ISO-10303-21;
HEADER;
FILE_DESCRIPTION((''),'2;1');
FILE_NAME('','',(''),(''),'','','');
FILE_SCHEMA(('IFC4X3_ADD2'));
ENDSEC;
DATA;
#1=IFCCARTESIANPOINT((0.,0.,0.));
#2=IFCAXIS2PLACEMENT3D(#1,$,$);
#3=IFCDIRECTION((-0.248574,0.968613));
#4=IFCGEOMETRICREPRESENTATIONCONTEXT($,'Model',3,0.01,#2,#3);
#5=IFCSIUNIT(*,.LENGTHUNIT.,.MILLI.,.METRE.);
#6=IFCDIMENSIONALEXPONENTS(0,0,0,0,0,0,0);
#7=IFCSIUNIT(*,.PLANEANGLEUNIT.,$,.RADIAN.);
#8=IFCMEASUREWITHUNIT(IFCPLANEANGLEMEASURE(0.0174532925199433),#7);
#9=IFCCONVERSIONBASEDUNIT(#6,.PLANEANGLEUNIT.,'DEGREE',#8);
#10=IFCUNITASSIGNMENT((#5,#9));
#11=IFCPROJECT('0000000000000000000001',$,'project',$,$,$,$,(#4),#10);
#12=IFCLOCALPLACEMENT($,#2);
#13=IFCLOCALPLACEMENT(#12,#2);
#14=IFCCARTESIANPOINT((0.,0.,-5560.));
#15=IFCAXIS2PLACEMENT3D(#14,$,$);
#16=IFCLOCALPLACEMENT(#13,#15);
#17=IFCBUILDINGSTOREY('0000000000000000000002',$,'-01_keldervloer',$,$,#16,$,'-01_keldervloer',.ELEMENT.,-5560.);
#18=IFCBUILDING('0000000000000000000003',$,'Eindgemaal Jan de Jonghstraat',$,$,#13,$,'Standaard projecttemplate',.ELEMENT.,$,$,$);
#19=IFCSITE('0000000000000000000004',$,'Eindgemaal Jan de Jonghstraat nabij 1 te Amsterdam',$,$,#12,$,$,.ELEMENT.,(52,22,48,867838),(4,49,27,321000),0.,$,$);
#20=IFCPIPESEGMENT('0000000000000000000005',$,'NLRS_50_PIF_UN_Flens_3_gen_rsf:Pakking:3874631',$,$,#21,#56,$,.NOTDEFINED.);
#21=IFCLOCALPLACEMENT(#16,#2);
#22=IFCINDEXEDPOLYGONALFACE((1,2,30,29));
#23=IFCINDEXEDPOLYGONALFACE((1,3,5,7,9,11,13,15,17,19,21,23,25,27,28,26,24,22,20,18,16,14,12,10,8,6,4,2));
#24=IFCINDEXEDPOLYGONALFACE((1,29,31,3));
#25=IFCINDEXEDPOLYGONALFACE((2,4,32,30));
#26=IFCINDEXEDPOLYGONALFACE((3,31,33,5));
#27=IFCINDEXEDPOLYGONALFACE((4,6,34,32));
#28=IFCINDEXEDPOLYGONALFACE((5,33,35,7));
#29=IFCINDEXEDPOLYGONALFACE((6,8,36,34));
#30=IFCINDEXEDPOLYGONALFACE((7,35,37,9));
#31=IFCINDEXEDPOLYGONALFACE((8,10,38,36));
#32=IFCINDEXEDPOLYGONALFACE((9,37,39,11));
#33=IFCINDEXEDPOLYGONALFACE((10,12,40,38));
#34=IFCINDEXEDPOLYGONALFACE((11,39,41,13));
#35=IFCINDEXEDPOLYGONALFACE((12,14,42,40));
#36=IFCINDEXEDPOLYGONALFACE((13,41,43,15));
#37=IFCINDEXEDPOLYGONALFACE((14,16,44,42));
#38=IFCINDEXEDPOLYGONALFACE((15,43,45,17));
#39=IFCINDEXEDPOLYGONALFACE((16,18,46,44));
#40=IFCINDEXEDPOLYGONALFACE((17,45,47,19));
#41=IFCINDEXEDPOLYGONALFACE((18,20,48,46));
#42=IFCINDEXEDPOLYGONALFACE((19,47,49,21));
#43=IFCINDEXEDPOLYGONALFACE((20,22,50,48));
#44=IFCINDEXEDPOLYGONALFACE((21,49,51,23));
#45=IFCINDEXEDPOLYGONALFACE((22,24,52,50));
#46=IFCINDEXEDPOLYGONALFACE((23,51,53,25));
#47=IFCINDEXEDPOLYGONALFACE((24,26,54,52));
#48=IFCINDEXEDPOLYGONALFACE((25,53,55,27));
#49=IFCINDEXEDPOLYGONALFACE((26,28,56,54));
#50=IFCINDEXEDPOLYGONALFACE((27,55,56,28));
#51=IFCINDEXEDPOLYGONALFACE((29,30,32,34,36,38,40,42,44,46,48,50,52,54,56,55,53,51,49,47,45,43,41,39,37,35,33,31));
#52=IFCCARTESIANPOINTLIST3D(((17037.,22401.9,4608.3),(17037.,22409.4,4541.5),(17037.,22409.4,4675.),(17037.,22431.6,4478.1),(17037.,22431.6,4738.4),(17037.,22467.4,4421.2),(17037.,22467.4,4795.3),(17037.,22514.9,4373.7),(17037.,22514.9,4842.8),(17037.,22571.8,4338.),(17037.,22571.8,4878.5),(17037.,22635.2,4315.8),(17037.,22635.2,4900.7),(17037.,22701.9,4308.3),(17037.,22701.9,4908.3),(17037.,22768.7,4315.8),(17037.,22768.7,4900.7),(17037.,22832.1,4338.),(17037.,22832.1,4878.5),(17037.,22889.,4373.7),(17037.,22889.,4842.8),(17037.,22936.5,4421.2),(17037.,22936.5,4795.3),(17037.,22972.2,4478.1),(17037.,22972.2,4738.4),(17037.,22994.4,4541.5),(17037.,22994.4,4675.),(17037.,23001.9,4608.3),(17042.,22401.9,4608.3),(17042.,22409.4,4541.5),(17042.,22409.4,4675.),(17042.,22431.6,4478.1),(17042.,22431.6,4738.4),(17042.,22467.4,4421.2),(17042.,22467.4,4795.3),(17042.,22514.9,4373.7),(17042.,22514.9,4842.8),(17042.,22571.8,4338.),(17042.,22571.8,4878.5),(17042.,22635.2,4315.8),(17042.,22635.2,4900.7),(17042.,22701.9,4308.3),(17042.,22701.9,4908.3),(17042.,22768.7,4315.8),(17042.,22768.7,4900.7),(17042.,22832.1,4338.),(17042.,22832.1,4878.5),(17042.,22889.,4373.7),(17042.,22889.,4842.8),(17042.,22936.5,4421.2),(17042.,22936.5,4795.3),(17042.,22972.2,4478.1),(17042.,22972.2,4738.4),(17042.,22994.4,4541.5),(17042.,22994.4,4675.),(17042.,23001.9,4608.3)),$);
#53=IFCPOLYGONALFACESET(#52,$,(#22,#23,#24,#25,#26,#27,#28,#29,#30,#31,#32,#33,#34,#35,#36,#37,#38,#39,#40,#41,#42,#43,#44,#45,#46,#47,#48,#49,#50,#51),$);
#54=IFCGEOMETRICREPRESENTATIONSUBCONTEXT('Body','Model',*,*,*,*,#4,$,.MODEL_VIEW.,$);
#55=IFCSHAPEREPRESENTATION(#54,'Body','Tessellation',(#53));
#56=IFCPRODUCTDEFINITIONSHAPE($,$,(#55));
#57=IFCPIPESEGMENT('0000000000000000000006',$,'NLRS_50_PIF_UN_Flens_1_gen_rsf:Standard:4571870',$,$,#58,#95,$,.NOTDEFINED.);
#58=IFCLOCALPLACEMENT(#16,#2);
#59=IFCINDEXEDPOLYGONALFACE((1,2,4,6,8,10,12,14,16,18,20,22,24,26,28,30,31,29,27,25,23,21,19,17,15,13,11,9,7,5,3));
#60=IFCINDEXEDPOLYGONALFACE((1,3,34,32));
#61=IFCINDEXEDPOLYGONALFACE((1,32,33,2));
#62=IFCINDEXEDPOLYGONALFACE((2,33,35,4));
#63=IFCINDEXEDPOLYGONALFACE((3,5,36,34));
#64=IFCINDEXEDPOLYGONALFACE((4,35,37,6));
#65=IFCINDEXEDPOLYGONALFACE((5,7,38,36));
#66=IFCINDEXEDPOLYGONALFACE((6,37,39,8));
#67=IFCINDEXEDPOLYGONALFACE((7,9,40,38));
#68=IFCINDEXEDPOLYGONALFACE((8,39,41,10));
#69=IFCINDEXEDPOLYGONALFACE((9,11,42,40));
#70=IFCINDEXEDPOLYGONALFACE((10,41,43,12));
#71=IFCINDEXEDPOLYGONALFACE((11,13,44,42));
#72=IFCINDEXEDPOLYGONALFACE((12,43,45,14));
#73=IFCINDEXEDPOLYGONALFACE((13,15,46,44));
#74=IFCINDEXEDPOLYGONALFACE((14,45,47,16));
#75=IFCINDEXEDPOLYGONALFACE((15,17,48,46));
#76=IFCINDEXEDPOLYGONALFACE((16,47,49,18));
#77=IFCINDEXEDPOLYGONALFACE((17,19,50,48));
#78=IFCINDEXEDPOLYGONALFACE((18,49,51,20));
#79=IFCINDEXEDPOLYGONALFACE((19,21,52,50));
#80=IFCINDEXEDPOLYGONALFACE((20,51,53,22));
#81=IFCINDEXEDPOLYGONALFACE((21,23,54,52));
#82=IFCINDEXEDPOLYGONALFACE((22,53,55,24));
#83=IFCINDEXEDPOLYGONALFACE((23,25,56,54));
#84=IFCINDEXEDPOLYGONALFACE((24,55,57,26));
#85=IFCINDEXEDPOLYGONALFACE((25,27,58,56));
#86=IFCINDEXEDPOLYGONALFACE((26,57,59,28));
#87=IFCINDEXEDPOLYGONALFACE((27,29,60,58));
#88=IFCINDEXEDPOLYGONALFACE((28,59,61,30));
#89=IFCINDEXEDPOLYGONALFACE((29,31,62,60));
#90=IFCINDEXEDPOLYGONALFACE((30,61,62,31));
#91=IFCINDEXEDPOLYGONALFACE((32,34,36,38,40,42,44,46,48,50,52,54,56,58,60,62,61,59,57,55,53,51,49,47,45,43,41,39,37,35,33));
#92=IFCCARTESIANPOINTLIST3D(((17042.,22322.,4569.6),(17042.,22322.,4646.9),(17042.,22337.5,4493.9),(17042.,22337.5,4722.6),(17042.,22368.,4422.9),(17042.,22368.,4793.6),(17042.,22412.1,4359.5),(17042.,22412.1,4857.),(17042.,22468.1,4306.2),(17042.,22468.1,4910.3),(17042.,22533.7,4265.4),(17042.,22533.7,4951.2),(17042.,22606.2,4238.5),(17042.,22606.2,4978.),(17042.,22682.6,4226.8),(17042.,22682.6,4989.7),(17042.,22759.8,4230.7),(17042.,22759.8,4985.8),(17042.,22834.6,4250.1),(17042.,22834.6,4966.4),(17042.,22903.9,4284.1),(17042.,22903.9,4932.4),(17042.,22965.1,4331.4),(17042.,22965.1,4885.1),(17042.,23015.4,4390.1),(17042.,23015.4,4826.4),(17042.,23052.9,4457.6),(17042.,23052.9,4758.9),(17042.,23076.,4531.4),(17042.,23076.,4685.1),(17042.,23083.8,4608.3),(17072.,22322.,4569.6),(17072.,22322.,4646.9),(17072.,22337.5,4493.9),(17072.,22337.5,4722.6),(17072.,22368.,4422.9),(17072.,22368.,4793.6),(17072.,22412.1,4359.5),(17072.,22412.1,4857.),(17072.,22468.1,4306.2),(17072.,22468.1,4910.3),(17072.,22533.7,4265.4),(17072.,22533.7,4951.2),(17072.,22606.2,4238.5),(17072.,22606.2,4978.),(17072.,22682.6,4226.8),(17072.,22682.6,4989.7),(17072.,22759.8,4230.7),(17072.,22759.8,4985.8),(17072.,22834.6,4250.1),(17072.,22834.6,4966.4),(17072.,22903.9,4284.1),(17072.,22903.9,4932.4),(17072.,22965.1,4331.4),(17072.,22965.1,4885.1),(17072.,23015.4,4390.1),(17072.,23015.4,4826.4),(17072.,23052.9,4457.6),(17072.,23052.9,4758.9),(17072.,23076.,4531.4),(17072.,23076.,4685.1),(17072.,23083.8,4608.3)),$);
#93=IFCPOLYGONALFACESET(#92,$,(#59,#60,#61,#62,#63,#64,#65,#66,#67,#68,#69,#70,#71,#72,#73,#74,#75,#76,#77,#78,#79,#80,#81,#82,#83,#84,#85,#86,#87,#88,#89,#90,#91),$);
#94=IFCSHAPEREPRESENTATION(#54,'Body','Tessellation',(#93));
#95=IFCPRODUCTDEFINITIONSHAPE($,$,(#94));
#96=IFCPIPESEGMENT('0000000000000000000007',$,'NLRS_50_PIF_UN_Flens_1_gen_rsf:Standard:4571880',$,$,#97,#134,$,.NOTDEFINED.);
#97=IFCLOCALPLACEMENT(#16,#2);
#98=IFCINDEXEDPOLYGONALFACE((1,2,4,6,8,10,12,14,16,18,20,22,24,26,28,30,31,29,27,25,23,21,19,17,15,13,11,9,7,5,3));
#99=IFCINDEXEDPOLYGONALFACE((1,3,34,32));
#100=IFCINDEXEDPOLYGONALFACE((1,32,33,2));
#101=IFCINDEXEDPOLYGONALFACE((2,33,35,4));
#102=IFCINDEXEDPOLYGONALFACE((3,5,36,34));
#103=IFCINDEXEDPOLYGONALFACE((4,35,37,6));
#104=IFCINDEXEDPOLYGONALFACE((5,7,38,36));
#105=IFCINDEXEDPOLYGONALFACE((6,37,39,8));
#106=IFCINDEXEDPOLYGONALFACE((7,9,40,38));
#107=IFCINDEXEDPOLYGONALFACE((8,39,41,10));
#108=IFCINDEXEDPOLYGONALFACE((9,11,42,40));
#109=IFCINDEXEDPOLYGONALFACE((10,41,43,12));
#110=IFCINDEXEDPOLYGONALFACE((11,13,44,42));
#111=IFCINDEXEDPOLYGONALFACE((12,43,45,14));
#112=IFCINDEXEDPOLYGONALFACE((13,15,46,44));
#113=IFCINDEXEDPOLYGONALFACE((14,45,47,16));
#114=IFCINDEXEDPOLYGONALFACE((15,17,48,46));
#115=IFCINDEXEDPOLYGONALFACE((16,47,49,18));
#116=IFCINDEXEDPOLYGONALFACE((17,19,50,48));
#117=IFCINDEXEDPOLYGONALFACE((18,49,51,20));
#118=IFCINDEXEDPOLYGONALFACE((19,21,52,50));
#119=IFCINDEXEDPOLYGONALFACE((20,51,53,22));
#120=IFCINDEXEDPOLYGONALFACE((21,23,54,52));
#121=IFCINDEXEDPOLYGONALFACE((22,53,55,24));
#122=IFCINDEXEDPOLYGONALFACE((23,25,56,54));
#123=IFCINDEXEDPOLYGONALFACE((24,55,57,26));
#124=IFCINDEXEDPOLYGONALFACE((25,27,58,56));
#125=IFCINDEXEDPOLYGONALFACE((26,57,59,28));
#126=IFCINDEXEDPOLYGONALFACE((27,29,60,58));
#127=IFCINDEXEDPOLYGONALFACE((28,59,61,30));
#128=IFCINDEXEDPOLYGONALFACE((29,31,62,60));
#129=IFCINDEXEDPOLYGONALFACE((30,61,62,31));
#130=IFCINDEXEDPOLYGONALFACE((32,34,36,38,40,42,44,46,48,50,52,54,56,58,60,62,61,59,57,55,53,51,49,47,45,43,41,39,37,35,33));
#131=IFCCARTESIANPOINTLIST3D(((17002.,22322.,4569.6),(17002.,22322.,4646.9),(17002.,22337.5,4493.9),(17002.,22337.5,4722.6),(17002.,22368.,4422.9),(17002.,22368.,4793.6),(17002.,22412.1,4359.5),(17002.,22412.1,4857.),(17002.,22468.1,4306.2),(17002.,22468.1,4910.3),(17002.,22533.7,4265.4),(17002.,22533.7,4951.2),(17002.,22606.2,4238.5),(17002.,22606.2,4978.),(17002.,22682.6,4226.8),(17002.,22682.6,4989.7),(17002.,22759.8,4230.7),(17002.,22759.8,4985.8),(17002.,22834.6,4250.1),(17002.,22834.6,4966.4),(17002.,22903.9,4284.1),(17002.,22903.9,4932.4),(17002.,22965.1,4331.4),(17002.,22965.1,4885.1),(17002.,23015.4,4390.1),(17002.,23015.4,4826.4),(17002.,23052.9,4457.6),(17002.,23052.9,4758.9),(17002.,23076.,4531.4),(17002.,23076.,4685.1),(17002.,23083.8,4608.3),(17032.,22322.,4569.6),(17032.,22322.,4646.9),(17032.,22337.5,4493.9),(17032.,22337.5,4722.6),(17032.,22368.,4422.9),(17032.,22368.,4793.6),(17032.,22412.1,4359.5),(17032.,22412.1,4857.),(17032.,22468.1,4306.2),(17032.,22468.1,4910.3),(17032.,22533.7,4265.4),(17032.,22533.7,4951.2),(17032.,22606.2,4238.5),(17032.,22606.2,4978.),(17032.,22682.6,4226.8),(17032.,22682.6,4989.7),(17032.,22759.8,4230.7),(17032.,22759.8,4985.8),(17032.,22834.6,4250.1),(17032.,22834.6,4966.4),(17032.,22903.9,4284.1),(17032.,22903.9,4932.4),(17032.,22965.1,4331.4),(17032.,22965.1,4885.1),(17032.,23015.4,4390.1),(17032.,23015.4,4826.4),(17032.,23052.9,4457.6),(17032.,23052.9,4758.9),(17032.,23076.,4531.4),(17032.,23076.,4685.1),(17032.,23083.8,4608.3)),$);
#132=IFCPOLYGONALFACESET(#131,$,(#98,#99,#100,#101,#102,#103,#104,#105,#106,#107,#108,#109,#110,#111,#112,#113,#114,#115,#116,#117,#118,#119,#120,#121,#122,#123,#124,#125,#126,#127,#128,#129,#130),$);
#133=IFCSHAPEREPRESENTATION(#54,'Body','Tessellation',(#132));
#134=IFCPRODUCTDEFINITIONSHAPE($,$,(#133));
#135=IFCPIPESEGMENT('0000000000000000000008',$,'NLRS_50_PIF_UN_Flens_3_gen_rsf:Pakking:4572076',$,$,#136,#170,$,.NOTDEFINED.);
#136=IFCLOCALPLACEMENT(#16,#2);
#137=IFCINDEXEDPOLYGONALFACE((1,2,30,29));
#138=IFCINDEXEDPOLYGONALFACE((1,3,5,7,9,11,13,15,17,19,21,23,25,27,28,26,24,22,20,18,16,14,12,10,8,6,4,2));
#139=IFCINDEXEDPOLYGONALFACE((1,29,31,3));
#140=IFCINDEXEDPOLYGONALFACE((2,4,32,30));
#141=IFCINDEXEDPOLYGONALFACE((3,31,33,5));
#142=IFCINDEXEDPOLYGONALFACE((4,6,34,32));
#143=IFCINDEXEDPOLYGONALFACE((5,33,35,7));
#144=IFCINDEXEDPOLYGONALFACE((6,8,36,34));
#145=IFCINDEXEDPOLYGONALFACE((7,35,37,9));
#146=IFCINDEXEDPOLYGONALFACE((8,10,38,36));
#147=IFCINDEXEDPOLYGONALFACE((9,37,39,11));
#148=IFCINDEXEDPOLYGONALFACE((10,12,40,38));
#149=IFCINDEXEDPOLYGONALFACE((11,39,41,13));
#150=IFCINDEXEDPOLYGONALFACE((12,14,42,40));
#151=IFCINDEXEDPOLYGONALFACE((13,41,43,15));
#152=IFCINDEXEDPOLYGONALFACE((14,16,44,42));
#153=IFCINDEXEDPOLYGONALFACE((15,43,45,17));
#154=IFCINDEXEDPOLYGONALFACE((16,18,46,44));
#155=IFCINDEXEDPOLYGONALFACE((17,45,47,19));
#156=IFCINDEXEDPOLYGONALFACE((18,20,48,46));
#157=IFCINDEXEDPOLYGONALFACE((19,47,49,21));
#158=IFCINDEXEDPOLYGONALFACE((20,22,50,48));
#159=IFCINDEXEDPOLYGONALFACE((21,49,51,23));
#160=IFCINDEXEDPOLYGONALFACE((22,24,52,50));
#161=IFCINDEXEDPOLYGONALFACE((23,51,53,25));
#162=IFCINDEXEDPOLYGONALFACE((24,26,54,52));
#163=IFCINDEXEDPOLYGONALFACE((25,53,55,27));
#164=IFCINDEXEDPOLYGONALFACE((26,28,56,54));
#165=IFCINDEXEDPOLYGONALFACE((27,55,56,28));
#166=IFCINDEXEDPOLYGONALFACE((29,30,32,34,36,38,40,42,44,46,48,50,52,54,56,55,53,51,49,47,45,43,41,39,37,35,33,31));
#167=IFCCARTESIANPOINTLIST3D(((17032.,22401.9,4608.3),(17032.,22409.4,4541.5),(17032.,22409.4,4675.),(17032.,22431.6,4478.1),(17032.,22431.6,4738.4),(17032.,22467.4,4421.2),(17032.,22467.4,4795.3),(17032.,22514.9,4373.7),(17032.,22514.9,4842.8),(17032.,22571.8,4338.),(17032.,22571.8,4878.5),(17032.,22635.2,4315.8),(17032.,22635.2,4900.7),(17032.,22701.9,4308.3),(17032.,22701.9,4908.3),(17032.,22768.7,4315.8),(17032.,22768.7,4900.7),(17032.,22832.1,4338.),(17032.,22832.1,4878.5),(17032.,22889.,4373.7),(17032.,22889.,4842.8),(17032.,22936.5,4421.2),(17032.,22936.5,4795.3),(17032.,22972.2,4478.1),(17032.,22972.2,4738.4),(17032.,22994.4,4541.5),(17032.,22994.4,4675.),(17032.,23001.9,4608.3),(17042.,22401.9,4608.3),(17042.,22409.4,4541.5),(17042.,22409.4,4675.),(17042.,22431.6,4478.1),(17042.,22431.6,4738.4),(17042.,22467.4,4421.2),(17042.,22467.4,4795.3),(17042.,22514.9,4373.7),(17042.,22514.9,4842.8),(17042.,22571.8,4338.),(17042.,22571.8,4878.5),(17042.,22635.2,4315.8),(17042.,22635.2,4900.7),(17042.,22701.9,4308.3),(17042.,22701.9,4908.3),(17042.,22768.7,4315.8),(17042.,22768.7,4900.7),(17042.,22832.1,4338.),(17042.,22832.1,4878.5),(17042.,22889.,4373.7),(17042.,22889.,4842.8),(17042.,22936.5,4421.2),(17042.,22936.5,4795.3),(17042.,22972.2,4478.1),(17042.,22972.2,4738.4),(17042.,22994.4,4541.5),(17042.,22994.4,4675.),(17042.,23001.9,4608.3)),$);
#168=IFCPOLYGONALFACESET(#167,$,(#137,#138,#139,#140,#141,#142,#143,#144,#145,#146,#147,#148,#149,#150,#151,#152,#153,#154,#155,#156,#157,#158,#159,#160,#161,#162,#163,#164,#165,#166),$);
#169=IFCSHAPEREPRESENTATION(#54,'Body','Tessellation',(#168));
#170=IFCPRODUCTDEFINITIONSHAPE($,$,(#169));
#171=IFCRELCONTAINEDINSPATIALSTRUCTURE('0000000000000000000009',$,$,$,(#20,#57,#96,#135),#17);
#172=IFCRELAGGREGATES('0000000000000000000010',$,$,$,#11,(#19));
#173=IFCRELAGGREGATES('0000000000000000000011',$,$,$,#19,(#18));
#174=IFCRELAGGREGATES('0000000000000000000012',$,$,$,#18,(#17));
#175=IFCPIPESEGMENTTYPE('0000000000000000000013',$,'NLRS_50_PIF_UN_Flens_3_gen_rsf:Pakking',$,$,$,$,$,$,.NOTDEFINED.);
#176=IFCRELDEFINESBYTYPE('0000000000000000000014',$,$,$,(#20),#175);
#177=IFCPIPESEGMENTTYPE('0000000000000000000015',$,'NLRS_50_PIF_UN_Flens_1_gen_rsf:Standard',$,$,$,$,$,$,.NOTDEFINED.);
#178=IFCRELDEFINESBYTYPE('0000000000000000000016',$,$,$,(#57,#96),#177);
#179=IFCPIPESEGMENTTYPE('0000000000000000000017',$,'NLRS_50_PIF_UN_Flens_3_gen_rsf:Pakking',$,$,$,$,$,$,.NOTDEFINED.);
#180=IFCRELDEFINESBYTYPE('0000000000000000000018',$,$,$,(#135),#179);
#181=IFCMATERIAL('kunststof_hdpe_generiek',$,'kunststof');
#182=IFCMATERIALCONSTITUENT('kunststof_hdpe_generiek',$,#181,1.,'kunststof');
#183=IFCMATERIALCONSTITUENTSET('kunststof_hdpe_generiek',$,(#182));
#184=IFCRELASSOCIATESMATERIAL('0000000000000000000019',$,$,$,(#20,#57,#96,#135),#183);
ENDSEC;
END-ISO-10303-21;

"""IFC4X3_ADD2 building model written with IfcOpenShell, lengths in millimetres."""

from ifc_helpers import new_model, entity, si_unit, converted_unit, direction, frame, frame_2d, origin, place, context, subcontext, project, spatial, circle, extrude, source, transform, mapped, material, constituent, constituent_set, type_object, type_shapes, element, save


model = new_model("IFC4X3_ADD2")

# Units and contexts
model_context = context("Model", 3, precision=0.01, world=origin(), true_north=direction((-0.248574, 0.968613)))
body_context = subcontext(model_context, "Body", "Model", "MODEL_VIEW")
ifc_project = project(units=[si_unit("LENGTHUNIT", "METRE", prefix="MILLI"), converted_unit("PLANEANGLEUNIT", "DEGREE", entity("IfcPlaneAngleMeasure", 0.0174532925199433), si_unit("PLANEANGLEUNIT", "RADIAN"), dimensions=[0, 0, 0, 0, 0, 0, 0])], contexts=[model_context])

# Site, building, storey
site_placement = place(None, origin())
site = spatial("IfcSite", under=ifc_project, at=site_placement, Name="Eindgemaal Jan de Jonghstraat nabij 1 te Amsterdam", CompositionType="ELEMENT", RefLatitude=(52, 22, 48, 867838), RefLongitude=(4, 49, 27, 321000), RefElevation=0.0)
building_placement = place(site_placement, origin())
building = spatial("IfcBuilding", under=site, at=building_placement, Name="Eindgemaal Jan de Jonghstraat", LongName="Standaard projecttemplate", CompositionType="ELEMENT")
storey_placement = place(building_placement, frame((0.0, 0.0, -5560.0)))
storey = spatial("IfcBuildingStorey", under=building, at=storey_placement, Name="-01_keldervloer", LongName="-01_keldervloer", CompositionType="ELEMENT", Elevation=-5560.0)

# Pipe segments
ifc_material_1 = material(Name="kunststof_hdpe_generiek", Category="kunststof")
ifc_constituent_1 = constituent(ifc_material_1, Name="kunststof_hdpe_generiek", Category="kunststof", fraction=1.0)
ifc_constituent_set_1 = constituent_set(constituents=[ifc_constituent_1], Name="kunststof_hdpe_generiek")
pipe_segment_type_1 = type_object("IfcPipeSegmentType", Name="NLRS_50_PIF_UN_Flens_3_gen_rsf:Pakking", PredefinedType="NOTDEFINED")
shared_shape_1 = source(origin(), body_context, "Body", "SweptSolid", [
    extrude(circle(Radius=300.0, at=frame_2d((0.0, 0.0), x_axis=(1.0, 0.0))), frame((0.0, 0.0, 0.0), z_axis=(0.0, 0.0, 1.0), x_axis=(0.0, -1.0, 0.0)), (0.0, 0.0, 1.0), 5.0),
])
type_shapes(pipe_segment_type_1, [shared_shape_1])
pipe_segment_1_placement = place(storey_placement, frame((17037.0, 22701.9, 4608.3), z_axis=(1.0, 0.0, 0.0), x_axis=(0.0, 0.0, 1.0)))
element("IfcPipeSegment", 1, at=pipe_segment_1_placement, inside=storey, type_object=pipe_segment_type_1, material=ifc_constituent_set_1, Name="NLRS_50_PIF_UN_Flens_3_gen_rsf:Pakking:3874631", PredefinedType="NOTDEFINED", context=body_context, shape_type="MappedRepresentation", body=[
    mapped(shared_shape_1, transform((0.0, 0.0, 0.0), scale=1.0)),
])
pipe_segment_type_2 = type_object("IfcPipeSegmentType", Name="NLRS_50_PIF_UN_Flens_1_gen_rsf:Standard", PredefinedType="NOTDEFINED")
shared_shape_2 = source(origin(), body_context, "Body", "SweptSolid", [
    extrude(circle(Radius=381.9, at=frame_2d((0.0, 0.0), x_axis=(1.0, 0.0))), frame((-15.0, 0.0, 0.0), z_axis=(1.0, 0.0, 0.0), x_axis=(0.0, 1.0, 0.0)), (0.0, 0.0, 1.0), 30.0),
])
type_shapes(pipe_segment_type_2, [shared_shape_2])
for number, where, name in (
    (2, (17057.0, 22701.9, 4608.3), "NLRS_50_PIF_UN_Flens_1_gen_rsf:Standard:4571870"),
    (3, (17017.0, 22701.9, 4608.3), "NLRS_50_PIF_UN_Flens_1_gen_rsf:Standard:4571880"),
):
    element("IfcPipeSegment", number, at=place(storey_placement, frame(where)), inside=storey, type_object=pipe_segment_type_2, material=ifc_constituent_set_1, Name=name, PredefinedType="NOTDEFINED", context=body_context, shape_type="MappedRepresentation", body=[
        mapped(shared_shape_2, transform((0.0, 0.0, 0.0), scale=1.0)),
    ])
pipe_segment_type_3 = type_object("IfcPipeSegmentType", Name="NLRS_50_PIF_UN_Flens_3_gen_rsf:Pakking", PredefinedType="NOTDEFINED")
shared_shape_3 = source(origin(), body_context, "Body", "SweptSolid", [
    extrude(circle(Radius=300.0, at=frame_2d((0.0, 0.0), x_axis=(1.0, 0.0))), frame((0.0, 0.0, 0.0), z_axis=(0.0, 0.0, 1.0), x_axis=(0.0, -1.0, 0.0)), (0.0, 0.0, 1.0), 10.0),
])
type_shapes(pipe_segment_type_3, [shared_shape_3])
pipe_segment_2_placement = place(storey_placement, frame((17042.0, 22701.9, 4608.3), z_axis=(-1.0, 0.0, 0.0), x_axis=(0.0, 0.0, -1.0)))
element("IfcPipeSegment", 4, at=pipe_segment_2_placement, inside=storey, type_object=pipe_segment_type_3, material=ifc_constituent_set_1, Name="NLRS_50_PIF_UN_Flens_3_gen_rsf:Pakking:4572076", PredefinedType="NOTDEFINED", context=body_context, shape_type="MappedRepresentation", body=[
    mapped(shared_shape_3, transform((0.0, 0.0, 0.0), scale=1.0)),
])

save(model, "model.ifc")
